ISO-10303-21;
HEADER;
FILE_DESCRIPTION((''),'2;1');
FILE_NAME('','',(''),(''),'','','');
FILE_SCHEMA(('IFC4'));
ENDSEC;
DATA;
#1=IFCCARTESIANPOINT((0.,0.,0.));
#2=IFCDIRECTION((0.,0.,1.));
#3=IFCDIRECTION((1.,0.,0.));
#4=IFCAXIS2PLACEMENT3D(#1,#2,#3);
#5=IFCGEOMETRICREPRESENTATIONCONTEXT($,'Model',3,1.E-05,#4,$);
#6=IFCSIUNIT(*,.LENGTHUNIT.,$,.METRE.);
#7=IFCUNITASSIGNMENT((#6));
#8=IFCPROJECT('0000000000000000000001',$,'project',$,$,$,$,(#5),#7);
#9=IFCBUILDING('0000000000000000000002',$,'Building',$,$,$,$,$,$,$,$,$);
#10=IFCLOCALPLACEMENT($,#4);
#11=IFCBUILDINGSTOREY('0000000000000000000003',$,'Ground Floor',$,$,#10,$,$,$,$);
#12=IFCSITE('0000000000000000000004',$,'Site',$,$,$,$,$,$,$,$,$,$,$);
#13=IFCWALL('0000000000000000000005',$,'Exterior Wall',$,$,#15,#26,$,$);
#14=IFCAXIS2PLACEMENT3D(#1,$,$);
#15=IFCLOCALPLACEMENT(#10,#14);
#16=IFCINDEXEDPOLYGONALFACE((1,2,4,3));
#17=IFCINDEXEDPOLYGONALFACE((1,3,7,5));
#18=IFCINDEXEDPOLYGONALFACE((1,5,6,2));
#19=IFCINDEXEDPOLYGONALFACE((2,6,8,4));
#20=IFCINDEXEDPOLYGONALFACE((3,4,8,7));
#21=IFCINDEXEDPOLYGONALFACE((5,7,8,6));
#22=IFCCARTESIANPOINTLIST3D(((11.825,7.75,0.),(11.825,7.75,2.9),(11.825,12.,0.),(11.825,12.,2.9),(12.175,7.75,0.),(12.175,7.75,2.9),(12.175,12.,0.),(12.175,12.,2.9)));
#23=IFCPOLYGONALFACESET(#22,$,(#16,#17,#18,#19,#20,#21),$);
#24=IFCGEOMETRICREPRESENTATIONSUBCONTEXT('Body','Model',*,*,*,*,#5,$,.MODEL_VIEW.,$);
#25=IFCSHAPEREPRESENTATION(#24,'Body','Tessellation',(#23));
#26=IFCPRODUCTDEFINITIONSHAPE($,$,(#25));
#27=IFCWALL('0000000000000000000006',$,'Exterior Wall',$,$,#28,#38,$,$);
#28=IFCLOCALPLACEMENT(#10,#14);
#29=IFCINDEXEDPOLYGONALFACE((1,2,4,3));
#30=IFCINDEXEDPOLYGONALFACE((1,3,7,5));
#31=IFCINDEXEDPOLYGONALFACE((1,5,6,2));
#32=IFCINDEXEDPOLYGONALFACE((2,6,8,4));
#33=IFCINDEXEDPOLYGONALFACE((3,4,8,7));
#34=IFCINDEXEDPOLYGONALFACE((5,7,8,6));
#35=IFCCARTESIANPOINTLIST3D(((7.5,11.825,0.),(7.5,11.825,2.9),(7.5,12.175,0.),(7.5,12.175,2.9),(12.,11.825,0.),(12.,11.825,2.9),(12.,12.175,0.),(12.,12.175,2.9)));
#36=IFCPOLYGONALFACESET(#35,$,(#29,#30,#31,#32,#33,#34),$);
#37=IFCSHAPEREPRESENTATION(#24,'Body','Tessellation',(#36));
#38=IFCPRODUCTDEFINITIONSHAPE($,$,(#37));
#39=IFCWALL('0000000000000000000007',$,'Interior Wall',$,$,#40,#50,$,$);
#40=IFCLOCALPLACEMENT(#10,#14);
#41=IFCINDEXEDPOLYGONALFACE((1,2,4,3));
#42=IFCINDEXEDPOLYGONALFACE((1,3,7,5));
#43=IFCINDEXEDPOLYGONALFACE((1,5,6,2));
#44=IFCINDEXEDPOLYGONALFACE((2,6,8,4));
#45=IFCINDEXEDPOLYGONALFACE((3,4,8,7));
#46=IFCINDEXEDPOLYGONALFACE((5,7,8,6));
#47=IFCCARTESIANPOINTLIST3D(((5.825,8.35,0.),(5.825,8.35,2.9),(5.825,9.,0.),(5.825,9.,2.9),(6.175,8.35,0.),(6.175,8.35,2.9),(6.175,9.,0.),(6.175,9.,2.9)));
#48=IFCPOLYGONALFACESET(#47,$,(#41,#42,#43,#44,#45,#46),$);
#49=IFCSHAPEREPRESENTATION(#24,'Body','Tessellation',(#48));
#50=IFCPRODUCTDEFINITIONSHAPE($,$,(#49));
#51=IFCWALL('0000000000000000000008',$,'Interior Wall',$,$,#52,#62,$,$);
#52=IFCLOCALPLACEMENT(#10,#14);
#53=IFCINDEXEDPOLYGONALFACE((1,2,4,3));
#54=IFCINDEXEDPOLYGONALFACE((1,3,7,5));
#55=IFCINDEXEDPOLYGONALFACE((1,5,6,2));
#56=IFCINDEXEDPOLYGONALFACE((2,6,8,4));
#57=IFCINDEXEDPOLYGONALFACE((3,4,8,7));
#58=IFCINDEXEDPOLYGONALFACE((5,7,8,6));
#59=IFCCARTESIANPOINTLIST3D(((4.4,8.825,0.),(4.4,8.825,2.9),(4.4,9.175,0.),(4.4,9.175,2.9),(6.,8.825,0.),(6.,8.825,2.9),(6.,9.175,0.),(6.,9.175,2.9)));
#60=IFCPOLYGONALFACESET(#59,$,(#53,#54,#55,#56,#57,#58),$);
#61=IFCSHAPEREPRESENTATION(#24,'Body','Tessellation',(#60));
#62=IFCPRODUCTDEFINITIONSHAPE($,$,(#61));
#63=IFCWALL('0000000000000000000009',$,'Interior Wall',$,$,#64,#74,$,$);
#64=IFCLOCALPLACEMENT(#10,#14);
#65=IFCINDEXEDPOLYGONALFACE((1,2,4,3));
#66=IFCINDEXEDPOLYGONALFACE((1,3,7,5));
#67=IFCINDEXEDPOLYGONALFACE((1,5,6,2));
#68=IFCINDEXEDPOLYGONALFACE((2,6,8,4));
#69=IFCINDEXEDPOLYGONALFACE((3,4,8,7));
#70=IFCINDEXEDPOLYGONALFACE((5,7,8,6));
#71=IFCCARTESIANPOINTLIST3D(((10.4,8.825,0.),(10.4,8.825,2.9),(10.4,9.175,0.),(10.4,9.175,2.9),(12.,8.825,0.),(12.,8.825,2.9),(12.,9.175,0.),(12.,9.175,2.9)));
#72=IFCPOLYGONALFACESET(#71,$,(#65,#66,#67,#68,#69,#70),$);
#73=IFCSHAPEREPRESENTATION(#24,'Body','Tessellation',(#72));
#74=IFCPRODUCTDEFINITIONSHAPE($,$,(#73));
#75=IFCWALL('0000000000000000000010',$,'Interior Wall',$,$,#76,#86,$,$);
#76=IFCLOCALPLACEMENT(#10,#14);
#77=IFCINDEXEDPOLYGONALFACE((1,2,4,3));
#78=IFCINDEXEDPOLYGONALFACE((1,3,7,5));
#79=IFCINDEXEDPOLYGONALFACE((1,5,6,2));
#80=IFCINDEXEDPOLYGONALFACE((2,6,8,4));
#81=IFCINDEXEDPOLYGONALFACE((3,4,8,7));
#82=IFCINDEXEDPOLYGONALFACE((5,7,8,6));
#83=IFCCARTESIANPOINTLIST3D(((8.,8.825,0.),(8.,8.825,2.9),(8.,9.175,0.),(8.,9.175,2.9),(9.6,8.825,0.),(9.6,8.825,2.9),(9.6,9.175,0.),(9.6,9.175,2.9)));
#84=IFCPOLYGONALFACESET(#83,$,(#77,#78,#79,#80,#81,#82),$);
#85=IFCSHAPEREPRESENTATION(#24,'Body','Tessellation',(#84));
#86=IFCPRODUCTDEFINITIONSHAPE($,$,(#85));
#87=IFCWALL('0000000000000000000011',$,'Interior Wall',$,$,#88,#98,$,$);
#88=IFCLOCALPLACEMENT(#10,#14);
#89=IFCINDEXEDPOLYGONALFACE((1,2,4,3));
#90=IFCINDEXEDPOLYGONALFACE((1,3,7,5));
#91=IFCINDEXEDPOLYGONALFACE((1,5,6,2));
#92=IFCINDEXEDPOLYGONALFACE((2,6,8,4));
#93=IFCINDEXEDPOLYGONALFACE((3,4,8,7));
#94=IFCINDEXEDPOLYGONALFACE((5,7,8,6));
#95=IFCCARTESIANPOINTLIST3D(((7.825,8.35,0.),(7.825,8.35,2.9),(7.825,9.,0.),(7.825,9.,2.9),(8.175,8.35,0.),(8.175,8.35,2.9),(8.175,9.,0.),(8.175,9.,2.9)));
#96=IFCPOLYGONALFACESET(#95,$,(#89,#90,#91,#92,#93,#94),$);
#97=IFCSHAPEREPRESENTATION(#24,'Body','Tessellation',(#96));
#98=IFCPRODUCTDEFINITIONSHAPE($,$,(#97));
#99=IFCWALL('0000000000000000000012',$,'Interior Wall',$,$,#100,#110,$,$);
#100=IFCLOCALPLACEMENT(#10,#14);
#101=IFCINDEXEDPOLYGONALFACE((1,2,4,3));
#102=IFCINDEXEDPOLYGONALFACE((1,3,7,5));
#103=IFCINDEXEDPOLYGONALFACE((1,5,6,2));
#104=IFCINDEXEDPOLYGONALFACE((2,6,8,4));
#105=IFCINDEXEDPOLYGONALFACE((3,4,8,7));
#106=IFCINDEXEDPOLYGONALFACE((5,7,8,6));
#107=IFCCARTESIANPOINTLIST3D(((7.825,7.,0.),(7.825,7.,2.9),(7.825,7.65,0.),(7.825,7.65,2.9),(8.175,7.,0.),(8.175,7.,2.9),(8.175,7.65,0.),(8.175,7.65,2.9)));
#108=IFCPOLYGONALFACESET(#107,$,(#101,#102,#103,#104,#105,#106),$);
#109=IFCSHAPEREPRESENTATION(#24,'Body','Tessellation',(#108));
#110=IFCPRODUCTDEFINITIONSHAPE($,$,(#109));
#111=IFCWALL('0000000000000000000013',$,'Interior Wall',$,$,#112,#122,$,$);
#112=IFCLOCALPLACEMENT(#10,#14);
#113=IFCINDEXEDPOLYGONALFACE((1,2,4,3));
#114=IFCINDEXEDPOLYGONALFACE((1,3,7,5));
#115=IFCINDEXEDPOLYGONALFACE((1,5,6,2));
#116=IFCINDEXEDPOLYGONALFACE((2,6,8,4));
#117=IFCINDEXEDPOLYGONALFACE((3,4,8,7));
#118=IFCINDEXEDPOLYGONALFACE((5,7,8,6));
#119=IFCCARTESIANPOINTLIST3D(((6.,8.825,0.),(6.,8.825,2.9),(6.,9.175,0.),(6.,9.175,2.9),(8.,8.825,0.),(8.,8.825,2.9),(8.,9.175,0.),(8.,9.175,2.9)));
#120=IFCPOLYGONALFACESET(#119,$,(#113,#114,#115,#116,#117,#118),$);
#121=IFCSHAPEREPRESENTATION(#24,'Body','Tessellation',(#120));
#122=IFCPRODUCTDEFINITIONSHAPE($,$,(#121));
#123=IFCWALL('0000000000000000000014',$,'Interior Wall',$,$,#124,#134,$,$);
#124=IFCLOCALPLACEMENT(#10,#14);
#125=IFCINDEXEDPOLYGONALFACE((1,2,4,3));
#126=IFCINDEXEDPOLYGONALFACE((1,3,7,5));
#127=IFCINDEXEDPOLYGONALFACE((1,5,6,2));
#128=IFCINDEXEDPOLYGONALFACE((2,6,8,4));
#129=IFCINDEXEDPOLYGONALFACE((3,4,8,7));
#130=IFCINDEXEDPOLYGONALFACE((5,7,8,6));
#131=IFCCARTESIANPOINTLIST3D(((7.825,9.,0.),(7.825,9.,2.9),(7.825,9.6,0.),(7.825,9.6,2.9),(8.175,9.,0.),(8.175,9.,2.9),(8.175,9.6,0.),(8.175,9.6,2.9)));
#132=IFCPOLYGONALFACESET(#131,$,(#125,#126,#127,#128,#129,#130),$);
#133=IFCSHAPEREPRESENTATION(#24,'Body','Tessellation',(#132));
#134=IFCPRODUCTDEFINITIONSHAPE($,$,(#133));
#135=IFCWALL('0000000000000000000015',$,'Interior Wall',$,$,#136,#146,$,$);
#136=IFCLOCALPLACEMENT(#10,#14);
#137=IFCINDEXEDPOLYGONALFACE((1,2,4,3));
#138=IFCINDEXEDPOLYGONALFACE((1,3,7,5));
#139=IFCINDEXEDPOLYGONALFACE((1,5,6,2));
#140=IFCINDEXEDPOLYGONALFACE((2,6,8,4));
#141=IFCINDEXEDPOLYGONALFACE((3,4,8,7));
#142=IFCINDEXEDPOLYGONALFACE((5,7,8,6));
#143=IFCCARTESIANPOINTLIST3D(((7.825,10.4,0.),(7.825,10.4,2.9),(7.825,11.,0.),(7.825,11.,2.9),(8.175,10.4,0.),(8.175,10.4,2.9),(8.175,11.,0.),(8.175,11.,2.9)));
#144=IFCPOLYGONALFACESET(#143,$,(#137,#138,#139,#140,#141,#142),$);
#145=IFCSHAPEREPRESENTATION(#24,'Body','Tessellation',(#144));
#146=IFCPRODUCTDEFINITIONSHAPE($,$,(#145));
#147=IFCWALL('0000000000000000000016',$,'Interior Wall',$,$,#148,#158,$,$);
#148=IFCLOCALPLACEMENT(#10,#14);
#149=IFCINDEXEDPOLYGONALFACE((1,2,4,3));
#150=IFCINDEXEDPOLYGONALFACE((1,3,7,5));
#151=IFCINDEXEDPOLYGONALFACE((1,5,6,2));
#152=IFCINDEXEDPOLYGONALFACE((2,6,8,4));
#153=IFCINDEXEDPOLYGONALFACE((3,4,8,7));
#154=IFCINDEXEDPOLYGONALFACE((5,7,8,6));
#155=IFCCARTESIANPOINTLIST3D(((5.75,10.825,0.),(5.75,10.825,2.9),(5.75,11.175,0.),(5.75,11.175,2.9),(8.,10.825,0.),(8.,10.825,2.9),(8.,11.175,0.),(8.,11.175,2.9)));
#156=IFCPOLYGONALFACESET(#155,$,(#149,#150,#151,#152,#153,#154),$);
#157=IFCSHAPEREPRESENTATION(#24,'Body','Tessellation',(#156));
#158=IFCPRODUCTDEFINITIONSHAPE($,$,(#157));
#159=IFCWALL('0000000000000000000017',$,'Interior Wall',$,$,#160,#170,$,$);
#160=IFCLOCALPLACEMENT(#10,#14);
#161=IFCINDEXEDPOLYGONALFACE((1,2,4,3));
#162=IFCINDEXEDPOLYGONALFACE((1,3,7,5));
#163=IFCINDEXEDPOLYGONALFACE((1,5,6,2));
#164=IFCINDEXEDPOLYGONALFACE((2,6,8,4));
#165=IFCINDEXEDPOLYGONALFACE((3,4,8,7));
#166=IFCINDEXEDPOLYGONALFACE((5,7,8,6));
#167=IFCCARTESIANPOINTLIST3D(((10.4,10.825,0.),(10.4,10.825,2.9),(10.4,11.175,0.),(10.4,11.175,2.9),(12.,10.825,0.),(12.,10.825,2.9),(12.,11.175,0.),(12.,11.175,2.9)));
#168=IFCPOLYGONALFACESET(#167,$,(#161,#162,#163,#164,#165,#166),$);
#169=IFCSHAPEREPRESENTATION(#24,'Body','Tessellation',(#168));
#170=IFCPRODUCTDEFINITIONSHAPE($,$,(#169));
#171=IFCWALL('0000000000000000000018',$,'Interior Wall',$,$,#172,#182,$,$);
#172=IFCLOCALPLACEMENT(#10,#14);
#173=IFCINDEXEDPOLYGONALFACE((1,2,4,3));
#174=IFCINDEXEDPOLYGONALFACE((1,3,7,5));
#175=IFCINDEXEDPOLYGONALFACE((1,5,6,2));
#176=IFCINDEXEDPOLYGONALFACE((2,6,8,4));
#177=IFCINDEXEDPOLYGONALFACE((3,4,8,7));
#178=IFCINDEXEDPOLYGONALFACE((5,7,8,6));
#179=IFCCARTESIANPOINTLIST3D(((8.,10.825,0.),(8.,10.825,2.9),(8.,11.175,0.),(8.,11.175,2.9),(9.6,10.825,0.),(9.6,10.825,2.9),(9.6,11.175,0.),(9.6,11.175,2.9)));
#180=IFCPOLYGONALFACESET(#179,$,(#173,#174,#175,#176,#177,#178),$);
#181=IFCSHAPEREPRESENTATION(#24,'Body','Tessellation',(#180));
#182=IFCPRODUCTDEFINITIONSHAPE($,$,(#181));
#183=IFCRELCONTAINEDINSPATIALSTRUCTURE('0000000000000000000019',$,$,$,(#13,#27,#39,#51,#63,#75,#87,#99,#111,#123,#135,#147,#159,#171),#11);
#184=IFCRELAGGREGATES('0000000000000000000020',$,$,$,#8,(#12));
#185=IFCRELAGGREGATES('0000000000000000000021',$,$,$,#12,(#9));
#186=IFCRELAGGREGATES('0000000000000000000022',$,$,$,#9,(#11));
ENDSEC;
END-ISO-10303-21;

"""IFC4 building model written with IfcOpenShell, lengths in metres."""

from ifc_helpers import new_model, si_unit, frame, origin_with_axes, place, context, subcontext, project, spatial, indexed_curve, outline, extrude, element, save


model = new_model("IFC4")

# Units and contexts
model_context = context("Model", 3, precision=1e-05, world=origin_with_axes())
body_context = subcontext(model_context, "Body", "Model", "MODEL_VIEW")
ifc_project = project(units=[si_unit("LENGTHUNIT", "METRE")], contexts=[model_context])

# Site, building, storey
site = spatial("IfcSite", under=ifc_project, Name="Site")
building = spatial("IfcBuilding", under=site, Name="Building")
storey_placement = place(None, origin_with_axes())
storey = spatial("IfcBuildingStorey", under=building, at=storey_placement, Name="Ground Floor")

# Walls
wall_1_placement = place(storey_placement, frame((12.0, 7.75, 0.0), z_axis=(0.0, 0.0, 1.0), x_axis=(0.0, 1.0, 0.0)))
element("IfcWall", 1, at=wall_1_placement, inside=storey, Name="Exterior Wall", context=body_context, shape_type="SweptSolid", body=[
    extrude(outline(indexed_curve([(0.0, 0.0), (0.0, 0.35), (4.25, 0.35), (4.25, 0.0), (0.0, 0.0)], self_intersect=False)), frame((0.0, -0.175, 0.0), z_axis=(0.0, 0.0, 1.0), x_axis=(1.0, 0.0, 0.0)), (0.0, 0.0, 1.0), 2.9),
])
wall_2_placement = place(storey_placement, frame((12.0, 12.0, 0.0), z_axis=(0.0, 0.0, 1.0), x_axis=(-1.0, 0.0, 0.0)))
element("IfcWall", 2, at=wall_2_placement, inside=storey, Name="Exterior Wall", context=body_context, shape_type="SweptSolid", body=[
    extrude(outline(indexed_curve([(0.0, 0.0), (0.0, 0.35), (4.5, 0.35), (4.5, 0.0), (0.0, 0.0)], self_intersect=False)), frame((0.0, -0.175, 0.0), z_axis=(0.0, 0.0, 1.0), x_axis=(1.0, 0.0, 0.0)), (0.0, 0.0, 1.0), 2.9),
])
wall_3_placement = place(storey_placement, frame((6.0, 8.35, 0.0), z_axis=(0.0, 0.0, 1.0), x_axis=(0.0, 1.0, 0.0)))
element("IfcWall", 3, at=wall_3_placement, inside=storey, Name="Interior Wall", context=body_context, shape_type="SweptSolid", body=[
    extrude(outline(indexed_curve([(0.0, 0.0), (0.0, 0.35), (0.65, 0.35), (0.65, 0.0), (0.0, 0.0)], self_intersect=False)), frame((0.0, -0.175, 0.0), z_axis=(0.0, 0.0, 1.0), x_axis=(1.0, 0.0, 0.0)), (0.0, 0.0, 1.0), 2.9),
])
for number, where, z_axis, x_axis, name in (
    (4, (6.0, 9.0, 0.0), (0.0, 0.0, 1.0), (-1.0, 0.0, 0.0), "Interior Wall"),
    (5, (12.0, 9.0, 0.0), (0.0, 0.0, 1.0), (-1.0, 0.0, 0.0), "Interior Wall"),
    (6, (9.6, 9.0, 0.0), (0.0, 0.0, 1.0), (-1.0, 0.0, 0.0), "Interior Wall"),
):
    element("IfcWall", number, at=place(storey_placement, frame(where, z_axis=z_axis, x_axis=x_axis)), inside=storey, Name=name, context=body_context, shape_type="SweptSolid", body=[
        extrude(outline(indexed_curve([(0.0, 0.0), (0.0, 0.35), (1.6, 0.35), (1.6, 0.0), (0.0, 0.0)], self_intersect=False)), frame((0.0, -0.175, 0.0), z_axis=(0.0, 0.0, 1.0), x_axis=(1.0, 0.0, 0.0)), (0.0, 0.0, 1.0), 2.9),
    ])
for number, where, z_axis, x_axis, name in (
    (7, (8.0, 9.0, 0.0), (0.0, 0.0, 1.0), (0.0, -1.0, 0.0), "Interior Wall"),
    (8, (8.0, 7.65, 0.0), (0.0, 0.0, 1.0), (0.0, -1.0, 0.0), "Interior Wall"),
):
    element("IfcWall", number, at=place(storey_placement, frame(where, z_axis=z_axis, x_axis=x_axis)), inside=storey, Name=name, context=body_context, shape_type="SweptSolid", body=[
        extrude(outline(indexed_curve([(0.0, 0.0), (0.0, 0.35), (0.65, 0.35), (0.65, 0.0), (0.0, 0.0)], self_intersect=False)), frame((0.0, -0.175, 0.0), z_axis=(0.0, 0.0, 1.0), x_axis=(1.0, 0.0, 0.0)), (0.0, 0.0, 1.0), 2.9),
    ])
wall_4_placement = place(storey_placement, frame((8.0, 9.0, 0.0), z_axis=(0.0, 0.0, 1.0), x_axis=(-1.0, 0.0, 0.0)))
element("IfcWall", 9, at=wall_4_placement, inside=storey, Name="Interior Wall", context=body_context, shape_type="SweptSolid", body=[
    extrude(outline(indexed_curve([(0.0, 0.0), (0.0, 0.35), (2.0, 0.35), (2.0, 0.0), (0.0, 0.0)], self_intersect=False)), frame((0.0, -0.175, 0.0), z_axis=(0.0, 0.0, 1.0), x_axis=(1.0, 0.0, 0.0)), (0.0, 0.0, 1.0), 2.9),
])
for number, where, z_axis, x_axis, name in (
    (10, (8.0, 9.0, 0.0), (0.0, 0.0, 1.0), (0.0, 1.0, 0.0), "Interior Wall"),
    (11, (8.0, 10.4, 0.0), (0.0, 0.0, 1.0), (0.0, 1.0, 0.0), "Interior Wall"),
):
    element("IfcWall", number, at=place(storey_placement, frame(where, z_axis=z_axis, x_axis=x_axis)), inside=storey, Name=name, context=body_context, shape_type="SweptSolid", body=[
        extrude(outline(indexed_curve([(0.0, 0.0), (0.0, 0.35), (0.6, 0.35), (0.6, 0.0), (0.0, 0.0)], self_intersect=False)), frame((0.0, -0.175, 0.0), z_axis=(0.0, 0.0, 1.0), x_axis=(1.0, 0.0, 0.0)), (0.0, 0.0, 1.0), 2.9),
    ])
wall_5_placement = place(storey_placement, frame((8.0, 11.0, 0.0), z_axis=(0.0, 0.0, 1.0), x_axis=(-1.0, 0.0, 0.0)))
element("IfcWall", 12, at=wall_5_placement, inside=storey, Name="Interior Wall", context=body_context, shape_type="SweptSolid", body=[
    extrude(outline(indexed_curve([(0.0, 0.0), (0.0, 0.35), (2.25, 0.35), (2.25, 0.0), (0.0, 0.0)], self_intersect=False)), frame((0.0, -0.175, 0.0), z_axis=(0.0, 0.0, 1.0), x_axis=(1.0, 0.0, 0.0)), (0.0, 0.0, 1.0), 2.9),
])
for number, where, z_axis, x_axis, name in (
    (13, (12.0, 11.0, 0.0), (0.0, 0.0, 1.0), (-1.0, 0.0, 0.0), "Interior Wall"),
    (14, (9.6, 11.0, 0.0), (0.0, 0.0, 1.0), (-1.0, 0.0, 0.0), "Interior Wall"),
):
    element("IfcWall", number, at=place(storey_placement, frame(where, z_axis=z_axis, x_axis=x_axis)), inside=storey, Name=name, context=body_context, shape_type="SweptSolid", body=[
        extrude(outline(indexed_curve([(0.0, 0.0), (0.0, 0.35), (1.6, 0.35), (1.6, 0.0), (0.0, 0.0)], self_intersect=False)), frame((0.0, -0.175, 0.0), z_axis=(0.0, 0.0, 1.0), x_axis=(1.0, 0.0, 0.0)), (0.0, 0.0, 1.0), 2.9),
    ])

save(model, "model.ifc")
